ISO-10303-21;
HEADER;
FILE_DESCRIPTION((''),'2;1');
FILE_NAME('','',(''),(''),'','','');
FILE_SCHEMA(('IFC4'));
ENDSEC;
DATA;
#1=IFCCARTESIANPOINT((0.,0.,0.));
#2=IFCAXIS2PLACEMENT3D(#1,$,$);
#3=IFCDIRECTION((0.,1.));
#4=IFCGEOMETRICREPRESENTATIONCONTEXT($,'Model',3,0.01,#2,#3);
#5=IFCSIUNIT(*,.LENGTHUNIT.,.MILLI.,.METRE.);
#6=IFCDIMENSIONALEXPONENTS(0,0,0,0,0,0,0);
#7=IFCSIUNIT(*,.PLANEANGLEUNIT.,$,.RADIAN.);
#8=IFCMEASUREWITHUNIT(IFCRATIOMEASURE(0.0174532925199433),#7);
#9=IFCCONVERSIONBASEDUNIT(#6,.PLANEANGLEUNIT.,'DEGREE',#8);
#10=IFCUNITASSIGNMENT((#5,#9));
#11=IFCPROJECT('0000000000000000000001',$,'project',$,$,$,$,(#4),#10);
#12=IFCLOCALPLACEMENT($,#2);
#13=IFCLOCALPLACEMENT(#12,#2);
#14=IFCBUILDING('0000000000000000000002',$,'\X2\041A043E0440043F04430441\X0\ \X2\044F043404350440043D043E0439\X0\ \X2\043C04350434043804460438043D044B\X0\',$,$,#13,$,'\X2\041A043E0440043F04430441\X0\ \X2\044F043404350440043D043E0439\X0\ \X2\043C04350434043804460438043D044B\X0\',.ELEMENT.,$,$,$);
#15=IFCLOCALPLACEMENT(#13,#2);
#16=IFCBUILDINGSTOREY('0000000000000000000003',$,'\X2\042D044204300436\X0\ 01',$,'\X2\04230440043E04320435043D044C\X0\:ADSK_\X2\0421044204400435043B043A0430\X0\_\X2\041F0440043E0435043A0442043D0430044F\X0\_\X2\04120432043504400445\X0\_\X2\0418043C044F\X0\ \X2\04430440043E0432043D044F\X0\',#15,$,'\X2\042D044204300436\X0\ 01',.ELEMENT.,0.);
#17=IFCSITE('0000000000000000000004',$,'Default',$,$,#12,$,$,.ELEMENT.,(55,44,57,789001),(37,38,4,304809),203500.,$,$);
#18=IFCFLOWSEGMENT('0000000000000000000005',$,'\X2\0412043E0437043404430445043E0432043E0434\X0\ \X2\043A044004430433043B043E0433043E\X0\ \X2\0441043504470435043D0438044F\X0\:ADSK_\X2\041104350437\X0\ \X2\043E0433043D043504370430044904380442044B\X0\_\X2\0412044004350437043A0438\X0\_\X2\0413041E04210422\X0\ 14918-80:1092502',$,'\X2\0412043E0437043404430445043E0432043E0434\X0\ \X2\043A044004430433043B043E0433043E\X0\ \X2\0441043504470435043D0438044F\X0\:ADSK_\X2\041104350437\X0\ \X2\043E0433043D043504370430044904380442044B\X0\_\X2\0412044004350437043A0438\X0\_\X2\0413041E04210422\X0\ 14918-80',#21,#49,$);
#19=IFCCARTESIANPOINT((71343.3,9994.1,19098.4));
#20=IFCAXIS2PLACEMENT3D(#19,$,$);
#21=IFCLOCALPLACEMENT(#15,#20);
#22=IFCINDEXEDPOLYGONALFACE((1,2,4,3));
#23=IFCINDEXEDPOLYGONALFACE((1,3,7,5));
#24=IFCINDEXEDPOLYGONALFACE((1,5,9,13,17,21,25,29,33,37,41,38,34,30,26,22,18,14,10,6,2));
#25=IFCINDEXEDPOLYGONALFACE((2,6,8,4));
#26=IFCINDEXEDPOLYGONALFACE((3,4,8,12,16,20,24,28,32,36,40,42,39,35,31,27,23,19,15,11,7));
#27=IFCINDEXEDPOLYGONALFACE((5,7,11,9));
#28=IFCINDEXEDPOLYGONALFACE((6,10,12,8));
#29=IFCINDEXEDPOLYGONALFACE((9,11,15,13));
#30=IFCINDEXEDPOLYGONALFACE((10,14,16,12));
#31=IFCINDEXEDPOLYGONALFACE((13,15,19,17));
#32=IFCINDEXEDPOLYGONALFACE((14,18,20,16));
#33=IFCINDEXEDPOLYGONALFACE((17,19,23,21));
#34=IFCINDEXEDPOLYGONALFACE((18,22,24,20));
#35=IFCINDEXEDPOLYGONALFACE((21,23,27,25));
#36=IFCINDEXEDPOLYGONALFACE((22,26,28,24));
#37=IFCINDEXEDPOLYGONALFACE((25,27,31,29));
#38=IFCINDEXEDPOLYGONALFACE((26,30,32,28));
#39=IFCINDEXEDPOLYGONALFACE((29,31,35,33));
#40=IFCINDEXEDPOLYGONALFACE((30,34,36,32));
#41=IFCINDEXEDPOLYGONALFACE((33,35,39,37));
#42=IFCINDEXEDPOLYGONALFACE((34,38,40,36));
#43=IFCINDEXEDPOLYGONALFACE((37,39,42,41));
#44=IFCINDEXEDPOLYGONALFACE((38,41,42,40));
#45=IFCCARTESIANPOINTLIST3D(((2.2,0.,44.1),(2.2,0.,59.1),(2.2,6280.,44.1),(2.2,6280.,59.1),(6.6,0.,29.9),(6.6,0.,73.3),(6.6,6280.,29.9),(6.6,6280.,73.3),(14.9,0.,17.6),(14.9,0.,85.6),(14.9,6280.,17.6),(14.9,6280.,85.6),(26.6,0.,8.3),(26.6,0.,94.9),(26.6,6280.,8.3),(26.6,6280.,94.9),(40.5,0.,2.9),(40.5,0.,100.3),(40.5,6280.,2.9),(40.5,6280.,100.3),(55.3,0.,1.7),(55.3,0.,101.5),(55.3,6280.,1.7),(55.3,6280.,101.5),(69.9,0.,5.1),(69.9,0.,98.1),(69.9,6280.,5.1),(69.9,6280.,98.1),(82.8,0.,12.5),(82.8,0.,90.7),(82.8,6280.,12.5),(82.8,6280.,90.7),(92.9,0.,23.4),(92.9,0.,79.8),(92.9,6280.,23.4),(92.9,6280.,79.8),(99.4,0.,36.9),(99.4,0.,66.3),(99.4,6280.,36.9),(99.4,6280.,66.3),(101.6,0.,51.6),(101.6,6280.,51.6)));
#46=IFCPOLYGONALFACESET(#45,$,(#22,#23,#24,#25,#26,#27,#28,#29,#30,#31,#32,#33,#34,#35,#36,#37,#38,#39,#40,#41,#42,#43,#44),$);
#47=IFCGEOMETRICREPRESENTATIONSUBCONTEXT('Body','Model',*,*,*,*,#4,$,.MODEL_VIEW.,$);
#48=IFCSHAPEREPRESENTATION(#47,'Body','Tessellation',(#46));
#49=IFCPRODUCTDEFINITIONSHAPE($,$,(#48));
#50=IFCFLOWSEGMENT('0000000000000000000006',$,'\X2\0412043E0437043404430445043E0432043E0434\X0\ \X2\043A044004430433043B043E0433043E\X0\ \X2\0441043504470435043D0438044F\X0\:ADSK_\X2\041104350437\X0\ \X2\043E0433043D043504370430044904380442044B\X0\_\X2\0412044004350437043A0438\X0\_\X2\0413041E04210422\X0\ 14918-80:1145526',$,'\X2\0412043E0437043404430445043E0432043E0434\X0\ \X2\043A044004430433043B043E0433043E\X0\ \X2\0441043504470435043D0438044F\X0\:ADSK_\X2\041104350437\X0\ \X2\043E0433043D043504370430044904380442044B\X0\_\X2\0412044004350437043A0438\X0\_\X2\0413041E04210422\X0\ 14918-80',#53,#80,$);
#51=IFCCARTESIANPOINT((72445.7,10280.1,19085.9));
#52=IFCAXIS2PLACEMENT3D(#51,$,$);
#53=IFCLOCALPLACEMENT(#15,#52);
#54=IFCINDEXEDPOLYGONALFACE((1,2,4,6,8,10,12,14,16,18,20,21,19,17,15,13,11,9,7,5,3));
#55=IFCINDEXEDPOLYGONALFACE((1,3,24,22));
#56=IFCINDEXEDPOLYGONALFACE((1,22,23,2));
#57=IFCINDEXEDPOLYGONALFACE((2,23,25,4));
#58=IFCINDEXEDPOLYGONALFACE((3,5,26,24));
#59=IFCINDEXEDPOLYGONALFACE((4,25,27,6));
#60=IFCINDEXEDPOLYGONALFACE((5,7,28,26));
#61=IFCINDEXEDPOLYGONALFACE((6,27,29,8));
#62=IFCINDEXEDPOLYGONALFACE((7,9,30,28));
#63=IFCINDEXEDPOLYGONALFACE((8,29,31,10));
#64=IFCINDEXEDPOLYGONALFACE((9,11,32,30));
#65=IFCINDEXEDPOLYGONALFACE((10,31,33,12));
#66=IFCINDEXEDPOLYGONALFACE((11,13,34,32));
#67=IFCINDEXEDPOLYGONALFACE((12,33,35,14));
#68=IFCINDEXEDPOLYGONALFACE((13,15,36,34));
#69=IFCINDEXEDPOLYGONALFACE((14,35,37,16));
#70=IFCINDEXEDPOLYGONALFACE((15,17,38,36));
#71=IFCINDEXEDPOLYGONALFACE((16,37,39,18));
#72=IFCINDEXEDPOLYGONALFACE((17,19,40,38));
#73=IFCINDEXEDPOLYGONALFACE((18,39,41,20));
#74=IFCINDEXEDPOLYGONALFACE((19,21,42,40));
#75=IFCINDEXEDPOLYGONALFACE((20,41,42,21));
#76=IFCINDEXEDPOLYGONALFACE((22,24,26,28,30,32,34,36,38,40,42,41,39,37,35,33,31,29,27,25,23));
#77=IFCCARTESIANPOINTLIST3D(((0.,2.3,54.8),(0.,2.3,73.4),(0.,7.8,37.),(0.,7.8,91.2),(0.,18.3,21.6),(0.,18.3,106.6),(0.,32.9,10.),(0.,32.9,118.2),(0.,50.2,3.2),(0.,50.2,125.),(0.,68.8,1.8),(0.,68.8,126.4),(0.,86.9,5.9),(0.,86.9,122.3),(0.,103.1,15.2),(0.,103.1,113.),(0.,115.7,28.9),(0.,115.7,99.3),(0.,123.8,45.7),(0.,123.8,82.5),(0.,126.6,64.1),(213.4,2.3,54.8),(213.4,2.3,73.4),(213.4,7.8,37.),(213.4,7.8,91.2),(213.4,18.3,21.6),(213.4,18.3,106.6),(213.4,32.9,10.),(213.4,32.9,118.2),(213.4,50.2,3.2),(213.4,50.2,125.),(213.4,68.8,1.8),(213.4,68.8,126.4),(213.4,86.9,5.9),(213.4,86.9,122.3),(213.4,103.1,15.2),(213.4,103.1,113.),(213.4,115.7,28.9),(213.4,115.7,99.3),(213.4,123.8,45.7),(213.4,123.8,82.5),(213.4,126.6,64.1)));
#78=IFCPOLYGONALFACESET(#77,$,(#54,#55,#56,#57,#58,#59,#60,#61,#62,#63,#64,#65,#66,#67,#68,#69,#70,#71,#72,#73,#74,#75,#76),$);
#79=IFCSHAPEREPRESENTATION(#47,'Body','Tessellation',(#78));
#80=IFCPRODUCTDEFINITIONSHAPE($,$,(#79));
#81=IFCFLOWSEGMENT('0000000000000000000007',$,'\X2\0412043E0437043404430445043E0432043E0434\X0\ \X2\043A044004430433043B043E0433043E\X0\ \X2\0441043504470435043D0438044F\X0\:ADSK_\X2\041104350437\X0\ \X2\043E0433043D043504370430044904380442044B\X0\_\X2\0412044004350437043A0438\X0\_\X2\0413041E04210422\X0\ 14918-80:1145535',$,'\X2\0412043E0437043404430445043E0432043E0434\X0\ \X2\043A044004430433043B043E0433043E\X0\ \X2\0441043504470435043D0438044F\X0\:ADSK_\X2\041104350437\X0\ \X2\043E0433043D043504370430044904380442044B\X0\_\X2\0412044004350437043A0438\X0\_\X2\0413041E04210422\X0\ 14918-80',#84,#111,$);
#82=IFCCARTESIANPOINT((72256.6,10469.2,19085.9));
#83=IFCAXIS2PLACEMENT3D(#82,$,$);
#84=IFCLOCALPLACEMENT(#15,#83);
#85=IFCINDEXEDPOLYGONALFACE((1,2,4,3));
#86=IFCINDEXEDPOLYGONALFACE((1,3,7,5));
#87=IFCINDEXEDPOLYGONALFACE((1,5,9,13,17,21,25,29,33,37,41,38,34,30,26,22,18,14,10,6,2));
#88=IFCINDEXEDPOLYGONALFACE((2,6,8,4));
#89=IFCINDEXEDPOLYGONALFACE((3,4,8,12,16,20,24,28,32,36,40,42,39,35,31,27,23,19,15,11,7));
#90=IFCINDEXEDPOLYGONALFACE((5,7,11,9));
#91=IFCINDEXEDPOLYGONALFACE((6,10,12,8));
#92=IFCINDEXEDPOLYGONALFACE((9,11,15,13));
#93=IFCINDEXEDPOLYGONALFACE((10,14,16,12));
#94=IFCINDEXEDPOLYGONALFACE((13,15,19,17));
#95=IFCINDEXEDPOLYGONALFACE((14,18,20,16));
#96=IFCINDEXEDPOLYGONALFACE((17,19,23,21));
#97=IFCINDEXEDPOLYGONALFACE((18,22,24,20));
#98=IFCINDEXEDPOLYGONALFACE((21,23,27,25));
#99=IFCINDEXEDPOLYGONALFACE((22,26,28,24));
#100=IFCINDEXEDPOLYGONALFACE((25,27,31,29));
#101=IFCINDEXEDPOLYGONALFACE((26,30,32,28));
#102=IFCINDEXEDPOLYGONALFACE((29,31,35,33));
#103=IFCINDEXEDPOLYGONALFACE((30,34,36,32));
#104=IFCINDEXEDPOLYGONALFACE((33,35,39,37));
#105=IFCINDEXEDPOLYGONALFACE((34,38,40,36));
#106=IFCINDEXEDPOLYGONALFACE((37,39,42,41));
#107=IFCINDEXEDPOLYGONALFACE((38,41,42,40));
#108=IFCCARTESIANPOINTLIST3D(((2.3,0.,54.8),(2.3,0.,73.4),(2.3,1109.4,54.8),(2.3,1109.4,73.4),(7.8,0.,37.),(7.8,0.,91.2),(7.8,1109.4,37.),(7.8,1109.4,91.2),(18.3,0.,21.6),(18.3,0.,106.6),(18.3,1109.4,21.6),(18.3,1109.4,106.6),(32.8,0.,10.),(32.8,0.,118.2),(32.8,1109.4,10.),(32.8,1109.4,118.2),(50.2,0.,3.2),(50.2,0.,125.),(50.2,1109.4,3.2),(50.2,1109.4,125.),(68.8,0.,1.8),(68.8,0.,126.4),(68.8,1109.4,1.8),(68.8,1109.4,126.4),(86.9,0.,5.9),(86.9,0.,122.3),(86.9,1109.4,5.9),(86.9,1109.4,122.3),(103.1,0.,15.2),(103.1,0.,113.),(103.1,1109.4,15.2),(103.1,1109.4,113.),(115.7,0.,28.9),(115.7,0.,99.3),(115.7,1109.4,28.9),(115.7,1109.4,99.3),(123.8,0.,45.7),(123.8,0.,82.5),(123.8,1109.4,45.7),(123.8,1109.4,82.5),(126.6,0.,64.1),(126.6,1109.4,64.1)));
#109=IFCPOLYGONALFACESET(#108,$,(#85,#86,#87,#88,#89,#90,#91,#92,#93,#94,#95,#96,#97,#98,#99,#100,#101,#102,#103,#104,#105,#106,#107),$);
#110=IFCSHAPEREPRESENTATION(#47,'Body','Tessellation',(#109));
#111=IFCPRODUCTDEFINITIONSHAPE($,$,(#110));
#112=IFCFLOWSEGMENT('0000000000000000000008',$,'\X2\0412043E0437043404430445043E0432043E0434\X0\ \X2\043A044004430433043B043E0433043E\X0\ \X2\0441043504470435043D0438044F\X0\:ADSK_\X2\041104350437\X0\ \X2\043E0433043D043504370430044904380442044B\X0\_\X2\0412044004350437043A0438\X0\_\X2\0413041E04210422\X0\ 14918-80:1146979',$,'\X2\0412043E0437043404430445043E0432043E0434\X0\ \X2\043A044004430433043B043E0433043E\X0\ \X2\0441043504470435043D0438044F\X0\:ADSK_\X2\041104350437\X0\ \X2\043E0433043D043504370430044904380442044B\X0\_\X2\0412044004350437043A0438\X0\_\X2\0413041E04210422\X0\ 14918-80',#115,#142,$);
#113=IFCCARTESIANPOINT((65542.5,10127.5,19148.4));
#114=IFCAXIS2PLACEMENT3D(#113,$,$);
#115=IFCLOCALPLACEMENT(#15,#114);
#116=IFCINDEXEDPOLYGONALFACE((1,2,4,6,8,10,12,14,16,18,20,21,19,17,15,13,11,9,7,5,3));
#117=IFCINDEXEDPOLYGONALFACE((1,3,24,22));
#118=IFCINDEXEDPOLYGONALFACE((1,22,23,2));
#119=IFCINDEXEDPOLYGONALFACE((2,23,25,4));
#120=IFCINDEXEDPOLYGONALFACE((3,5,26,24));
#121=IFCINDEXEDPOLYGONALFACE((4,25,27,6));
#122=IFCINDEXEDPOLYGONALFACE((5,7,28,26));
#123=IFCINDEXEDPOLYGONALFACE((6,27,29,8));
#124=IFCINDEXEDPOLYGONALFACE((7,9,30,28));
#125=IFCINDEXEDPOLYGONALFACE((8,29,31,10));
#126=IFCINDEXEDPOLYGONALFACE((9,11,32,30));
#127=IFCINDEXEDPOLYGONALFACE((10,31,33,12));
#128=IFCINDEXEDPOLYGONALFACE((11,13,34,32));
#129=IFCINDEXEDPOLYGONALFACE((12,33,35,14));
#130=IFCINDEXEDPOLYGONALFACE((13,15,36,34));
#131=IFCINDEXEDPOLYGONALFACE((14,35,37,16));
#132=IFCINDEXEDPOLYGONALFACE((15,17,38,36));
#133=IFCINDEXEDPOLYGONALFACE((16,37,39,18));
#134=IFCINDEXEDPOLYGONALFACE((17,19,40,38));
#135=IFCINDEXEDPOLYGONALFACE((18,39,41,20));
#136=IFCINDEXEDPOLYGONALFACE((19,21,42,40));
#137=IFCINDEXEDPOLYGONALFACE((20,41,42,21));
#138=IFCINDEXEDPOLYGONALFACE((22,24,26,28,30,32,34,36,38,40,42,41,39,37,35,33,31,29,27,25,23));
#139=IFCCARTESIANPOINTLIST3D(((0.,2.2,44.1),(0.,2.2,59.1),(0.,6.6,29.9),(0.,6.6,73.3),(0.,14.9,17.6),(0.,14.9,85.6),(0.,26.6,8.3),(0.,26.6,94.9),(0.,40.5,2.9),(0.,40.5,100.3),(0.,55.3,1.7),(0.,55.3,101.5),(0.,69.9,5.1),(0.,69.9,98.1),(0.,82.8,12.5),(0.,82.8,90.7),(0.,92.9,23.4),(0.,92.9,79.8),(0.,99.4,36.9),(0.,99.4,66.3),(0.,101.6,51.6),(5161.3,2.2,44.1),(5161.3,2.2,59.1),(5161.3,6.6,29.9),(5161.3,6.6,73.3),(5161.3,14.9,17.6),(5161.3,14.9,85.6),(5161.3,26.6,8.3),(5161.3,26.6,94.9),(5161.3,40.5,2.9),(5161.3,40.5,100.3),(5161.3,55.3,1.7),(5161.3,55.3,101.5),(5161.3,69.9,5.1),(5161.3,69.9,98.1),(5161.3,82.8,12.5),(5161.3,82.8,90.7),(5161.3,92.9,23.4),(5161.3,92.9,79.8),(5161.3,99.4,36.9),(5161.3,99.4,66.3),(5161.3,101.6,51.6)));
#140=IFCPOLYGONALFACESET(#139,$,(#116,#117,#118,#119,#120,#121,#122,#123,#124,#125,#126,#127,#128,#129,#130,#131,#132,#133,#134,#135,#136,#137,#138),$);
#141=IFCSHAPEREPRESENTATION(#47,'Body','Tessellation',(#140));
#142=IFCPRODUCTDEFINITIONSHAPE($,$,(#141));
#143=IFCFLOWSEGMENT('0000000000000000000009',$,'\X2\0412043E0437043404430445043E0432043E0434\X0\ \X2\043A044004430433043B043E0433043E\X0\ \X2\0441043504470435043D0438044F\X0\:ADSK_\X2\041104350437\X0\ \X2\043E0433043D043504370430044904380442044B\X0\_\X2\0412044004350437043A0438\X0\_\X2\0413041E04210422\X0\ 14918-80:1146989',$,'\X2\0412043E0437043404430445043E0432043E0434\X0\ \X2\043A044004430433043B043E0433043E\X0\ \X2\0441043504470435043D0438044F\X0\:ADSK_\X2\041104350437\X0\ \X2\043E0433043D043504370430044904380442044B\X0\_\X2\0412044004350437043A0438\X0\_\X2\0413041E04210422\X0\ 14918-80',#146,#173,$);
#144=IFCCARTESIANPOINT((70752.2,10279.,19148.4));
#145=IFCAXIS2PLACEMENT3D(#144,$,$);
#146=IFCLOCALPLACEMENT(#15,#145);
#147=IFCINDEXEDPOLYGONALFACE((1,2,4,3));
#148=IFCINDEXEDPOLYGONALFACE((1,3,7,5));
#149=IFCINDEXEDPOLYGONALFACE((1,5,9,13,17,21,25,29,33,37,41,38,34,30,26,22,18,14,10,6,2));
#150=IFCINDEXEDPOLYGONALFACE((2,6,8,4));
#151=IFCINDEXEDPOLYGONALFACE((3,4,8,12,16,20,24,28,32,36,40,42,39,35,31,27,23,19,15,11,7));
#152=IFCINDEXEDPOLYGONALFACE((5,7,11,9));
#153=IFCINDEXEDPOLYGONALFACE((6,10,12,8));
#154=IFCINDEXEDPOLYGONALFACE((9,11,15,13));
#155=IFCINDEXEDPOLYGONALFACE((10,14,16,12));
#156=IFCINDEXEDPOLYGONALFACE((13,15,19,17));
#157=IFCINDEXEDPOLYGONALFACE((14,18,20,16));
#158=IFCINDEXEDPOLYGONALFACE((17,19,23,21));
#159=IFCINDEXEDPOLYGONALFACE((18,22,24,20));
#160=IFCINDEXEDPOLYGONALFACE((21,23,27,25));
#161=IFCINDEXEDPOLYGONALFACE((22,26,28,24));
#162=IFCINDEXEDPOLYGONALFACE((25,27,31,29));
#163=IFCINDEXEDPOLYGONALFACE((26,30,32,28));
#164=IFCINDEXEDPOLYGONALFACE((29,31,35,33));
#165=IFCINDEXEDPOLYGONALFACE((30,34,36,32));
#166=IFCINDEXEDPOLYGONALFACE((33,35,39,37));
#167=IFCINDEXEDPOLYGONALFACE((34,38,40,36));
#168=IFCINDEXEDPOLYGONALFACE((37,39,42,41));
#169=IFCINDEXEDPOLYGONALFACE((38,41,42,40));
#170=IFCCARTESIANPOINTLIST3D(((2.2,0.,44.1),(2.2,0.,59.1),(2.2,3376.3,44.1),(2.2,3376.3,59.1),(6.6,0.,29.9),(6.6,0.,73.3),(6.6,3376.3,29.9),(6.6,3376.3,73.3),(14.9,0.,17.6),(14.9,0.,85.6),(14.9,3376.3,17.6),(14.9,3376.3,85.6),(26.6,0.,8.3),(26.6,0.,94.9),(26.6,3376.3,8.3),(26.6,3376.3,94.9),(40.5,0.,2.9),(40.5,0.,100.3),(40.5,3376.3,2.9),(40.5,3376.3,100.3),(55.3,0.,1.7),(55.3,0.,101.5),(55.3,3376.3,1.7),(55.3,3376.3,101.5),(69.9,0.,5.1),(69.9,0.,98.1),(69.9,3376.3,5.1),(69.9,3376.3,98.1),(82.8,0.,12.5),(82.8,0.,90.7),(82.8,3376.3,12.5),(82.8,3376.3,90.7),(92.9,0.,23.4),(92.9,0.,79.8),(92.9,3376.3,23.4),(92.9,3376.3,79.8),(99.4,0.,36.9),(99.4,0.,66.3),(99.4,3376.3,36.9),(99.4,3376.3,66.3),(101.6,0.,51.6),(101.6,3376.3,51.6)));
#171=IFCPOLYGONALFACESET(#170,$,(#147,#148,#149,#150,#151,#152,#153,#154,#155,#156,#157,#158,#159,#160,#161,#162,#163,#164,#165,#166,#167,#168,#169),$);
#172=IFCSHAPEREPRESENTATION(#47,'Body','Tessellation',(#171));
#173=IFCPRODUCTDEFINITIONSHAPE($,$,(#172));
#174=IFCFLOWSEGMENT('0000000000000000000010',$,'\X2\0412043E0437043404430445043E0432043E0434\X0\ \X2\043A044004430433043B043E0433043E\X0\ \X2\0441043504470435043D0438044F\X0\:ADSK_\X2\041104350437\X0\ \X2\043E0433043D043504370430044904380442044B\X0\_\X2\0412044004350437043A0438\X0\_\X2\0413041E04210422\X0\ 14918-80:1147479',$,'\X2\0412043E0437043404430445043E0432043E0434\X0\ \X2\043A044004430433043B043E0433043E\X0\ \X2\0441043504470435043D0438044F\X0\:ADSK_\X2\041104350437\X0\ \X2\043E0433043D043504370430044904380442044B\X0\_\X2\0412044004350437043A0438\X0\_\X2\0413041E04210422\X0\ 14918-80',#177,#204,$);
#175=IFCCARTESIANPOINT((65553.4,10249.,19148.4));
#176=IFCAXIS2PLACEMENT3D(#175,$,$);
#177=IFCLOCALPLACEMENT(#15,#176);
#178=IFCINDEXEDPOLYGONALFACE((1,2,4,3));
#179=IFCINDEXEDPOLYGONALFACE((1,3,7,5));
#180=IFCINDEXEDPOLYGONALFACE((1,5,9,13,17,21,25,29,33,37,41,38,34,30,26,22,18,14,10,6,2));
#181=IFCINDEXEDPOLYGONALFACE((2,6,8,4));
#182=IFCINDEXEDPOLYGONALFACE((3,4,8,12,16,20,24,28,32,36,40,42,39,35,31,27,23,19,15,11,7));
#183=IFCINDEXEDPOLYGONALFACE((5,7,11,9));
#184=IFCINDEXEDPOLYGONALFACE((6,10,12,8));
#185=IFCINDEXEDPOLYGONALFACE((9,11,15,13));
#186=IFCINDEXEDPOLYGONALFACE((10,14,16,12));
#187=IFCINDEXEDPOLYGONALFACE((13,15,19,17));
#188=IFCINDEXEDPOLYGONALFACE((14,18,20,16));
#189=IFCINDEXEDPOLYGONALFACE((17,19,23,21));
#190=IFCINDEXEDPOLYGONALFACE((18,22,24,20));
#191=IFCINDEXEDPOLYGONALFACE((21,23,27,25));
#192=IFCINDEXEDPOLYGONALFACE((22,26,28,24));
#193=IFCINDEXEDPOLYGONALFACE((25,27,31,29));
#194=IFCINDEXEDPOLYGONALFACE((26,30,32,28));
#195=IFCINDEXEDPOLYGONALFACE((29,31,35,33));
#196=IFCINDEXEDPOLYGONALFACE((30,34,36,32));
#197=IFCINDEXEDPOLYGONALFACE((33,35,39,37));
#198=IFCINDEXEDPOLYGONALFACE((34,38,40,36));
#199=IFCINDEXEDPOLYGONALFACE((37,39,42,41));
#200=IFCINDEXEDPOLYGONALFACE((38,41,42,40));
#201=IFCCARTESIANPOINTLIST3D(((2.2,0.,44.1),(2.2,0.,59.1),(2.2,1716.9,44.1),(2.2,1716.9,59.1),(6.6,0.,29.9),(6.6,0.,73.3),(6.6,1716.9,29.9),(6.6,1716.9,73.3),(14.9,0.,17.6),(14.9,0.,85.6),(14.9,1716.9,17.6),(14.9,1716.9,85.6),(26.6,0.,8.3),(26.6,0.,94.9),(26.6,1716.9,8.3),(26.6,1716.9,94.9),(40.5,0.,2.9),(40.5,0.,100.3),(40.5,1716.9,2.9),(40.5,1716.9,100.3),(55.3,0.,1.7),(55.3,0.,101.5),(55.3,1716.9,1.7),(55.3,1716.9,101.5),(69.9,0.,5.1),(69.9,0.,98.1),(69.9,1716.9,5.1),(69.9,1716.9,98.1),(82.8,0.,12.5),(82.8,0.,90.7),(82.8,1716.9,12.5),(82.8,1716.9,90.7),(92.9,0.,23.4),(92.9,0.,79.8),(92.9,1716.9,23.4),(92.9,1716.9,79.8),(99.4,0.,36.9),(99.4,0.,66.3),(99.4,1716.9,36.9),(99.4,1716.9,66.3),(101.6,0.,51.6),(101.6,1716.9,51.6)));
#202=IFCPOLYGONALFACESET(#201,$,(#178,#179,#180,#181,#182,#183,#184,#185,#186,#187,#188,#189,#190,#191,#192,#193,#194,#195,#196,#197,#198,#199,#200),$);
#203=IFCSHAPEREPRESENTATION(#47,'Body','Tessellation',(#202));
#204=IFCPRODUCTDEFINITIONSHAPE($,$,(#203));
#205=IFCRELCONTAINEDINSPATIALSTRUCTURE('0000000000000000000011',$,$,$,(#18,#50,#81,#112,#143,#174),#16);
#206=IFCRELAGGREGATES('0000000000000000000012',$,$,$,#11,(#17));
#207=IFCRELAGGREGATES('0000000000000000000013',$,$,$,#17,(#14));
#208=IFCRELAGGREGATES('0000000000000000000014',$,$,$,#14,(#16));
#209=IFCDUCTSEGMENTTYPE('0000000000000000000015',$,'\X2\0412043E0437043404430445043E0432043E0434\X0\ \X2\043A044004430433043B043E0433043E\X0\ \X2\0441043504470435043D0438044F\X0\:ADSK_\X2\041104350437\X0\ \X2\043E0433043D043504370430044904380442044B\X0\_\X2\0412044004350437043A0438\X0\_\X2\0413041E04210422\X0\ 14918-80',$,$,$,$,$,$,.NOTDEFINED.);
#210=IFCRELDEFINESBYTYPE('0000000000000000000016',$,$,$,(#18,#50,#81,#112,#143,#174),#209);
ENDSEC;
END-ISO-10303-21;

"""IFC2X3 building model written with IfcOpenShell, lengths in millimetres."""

from ifc_helpers import new_model, entity, si_unit, converted_unit, direction, frame, origin, origin_2d_with_axis, place, context, subcontext, project, spatial, circle, extrude, type_object, element, save


model = new_model("IFC2X3")

# Units and contexts
model_context = context("Model", 3, precision=0.01, world=origin(), true_north=direction((0.0, 1.0)))
body_context = subcontext(model_context, "Body", "Model", "MODEL_VIEW")
ifc_project = project(units=[si_unit("LENGTHUNIT", "METRE", prefix="MILLI"), converted_unit("PLANEANGLEUNIT", "DEGREE", entity("IfcRatioMeasure", 0.0174532925199433), si_unit("PLANEANGLEUNIT", "RADIAN"), dimensions=[0, 0, 0, 0, 0, 0, 0])], contexts=[model_context])

# Site, building, storey
site_placement = place(None, origin())
site = spatial("IfcSite", under=ifc_project, at=site_placement, Name="Default", CompositionType="ELEMENT", RefLatitude=(55, 44, 57, 789001), RefLongitude=(37, 38, 4, 304809), RefElevation=203500.0)
building_placement = place(site_placement, origin())
building = spatial("IfcBuilding", under=site, at=building_placement, Name="Корпус ядерной медицины", LongName="Корпус ядерной медицины", CompositionType="ELEMENT")
storey_placement = place(building_placement, origin())
storey = spatial("IfcBuildingStorey", under=building, at=storey_placement, Name="Этаж 01", ObjectType="Уровень:ADSK_Стрелка_Проектная_Вверх_Имя уровня", LongName="Этаж 01", CompositionType="ELEMENT", Elevation=0.0)

# Flow segments
duct_segment_type_1 = type_object("IfcDuctSegmentType", Name="Воздуховод круглого сечения:ADSK_Без огнезащиты_Врезки_ГОСТ 14918-80", PredefinedType="NOTDEFINED")
flow_segment_1_placement = place(storey_placement, frame((71343.3, 9994.1, 19098.4)))
element("IfcFlowSegment", 1, at=flow_segment_1_placement, inside=storey, type_object=duct_segment_type_1, Name="Воздуховод круглого сечения:ADSK_Без огнезащиты_Врезки_ГОСТ 14918-80:1092502", ObjectType="Воздуховод круглого сечения:ADSK_Без огнезащиты_Врезки_ГОСТ 14918-80", context=body_context, shape_type="SweptSolid", body=[
    extrude(circle(Radius=50.0, at=origin_2d_with_axis()), frame((51.6, 0.0, 51.6), z_axis=(0.0, 1.0, 0.0), x_axis=(1.0, 0.0, 0.0)), (0.0, 0.0, 1.0), 6280.0),
])
flow_segment_2_placement = place(storey_placement, frame((72445.7, 10280.1, 19085.9)))
element("IfcFlowSegment", 2, at=flow_segment_2_placement, inside=storey, type_object=duct_segment_type_1, Name="Воздуховод круглого сечения:ADSK_Без огнезащиты_Врезки_ГОСТ 14918-80:1145526", ObjectType="Воздуховод круглого сечения:ADSK_Без огнезащиты_Врезки_ГОСТ 14918-80", context=body_context, shape_type="SweptSolid", body=[
    extrude(circle(Radius=62.5, at=origin_2d_with_axis()), frame((0.0, 64.1, 64.1), z_axis=(1.0, 0.0, 0.0), x_axis=(0.0, 1.0, 0.0)), (0.0, 0.0, 1.0), 213.4),
])
flow_segment_3_placement = place(storey_placement, frame((72256.6, 10469.2, 19085.9)))
element("IfcFlowSegment", 3, at=flow_segment_3_placement, inside=storey, type_object=duct_segment_type_1, Name="Воздуховод круглого сечения:ADSK_Без огнезащиты_Врезки_ГОСТ 14918-80:1145535", ObjectType="Воздуховод круглого сечения:ADSK_Без огнезащиты_Врезки_ГОСТ 14918-80", context=body_context, shape_type="SweptSolid", body=[
    extrude(circle(Radius=62.5, at=origin_2d_with_axis()), frame((64.1, 0.0, 64.1), z_axis=(0.0, 1.0, 0.0), x_axis=(1.0, 0.0, 0.0)), (0.0, 0.0, 1.0), 1109.4),
])
flow_segment_4_placement = place(storey_placement, frame((65542.5, 10127.5, 19148.4)))
element("IfcFlowSegment", 4, at=flow_segment_4_placement, inside=storey, type_object=duct_segment_type_1, Name="Воздуховод круглого сечения:ADSK_Без огнезащиты_Врезки_ГОСТ 14918-80:1146979", ObjectType="Воздуховод круглого сечения:ADSK_Без огнезащиты_Врезки_ГОСТ 14918-80", context=body_context, shape_type="SweptSolid", body=[
    extrude(circle(Radius=50.0, at=origin_2d_with_axis()), frame((0.0, 51.6, 51.6), z_axis=(1.0, 0.0, 0.0), x_axis=(0.0, 1.0, 0.0)), (0.0, 0.0, 1.0), 5161.3),
])
flow_segment_5_placement = place(storey_placement, frame((70752.2, 10279.0, 19148.4)))
element("IfcFlowSegment", 5, at=flow_segment_5_placement, inside=storey, type_object=duct_segment_type_1, Name="Воздуховод круглого сечения:ADSK_Без огнезащиты_Врезки_ГОСТ 14918-80:1146989", ObjectType="Воздуховод круглого сечения:ADSK_Без огнезащиты_Врезки_ГОСТ 14918-80", context=body_context, shape_type="SweptSolid", body=[
    extrude(circle(Radius=50.0, at=origin_2d_with_axis()), frame((51.6, 0.0, 51.6), z_axis=(0.0, 1.0, 0.0), x_axis=(1.0, 0.0, 0.0)), (0.0, 0.0, 1.0), 3376.3),
])
flow_segment_6_placement = place(storey_placement, frame((65553.4, 10249.0, 19148.4)))
element("IfcFlowSegment", 6, at=flow_segment_6_placement, inside=storey, type_object=duct_segment_type_1, Name="Воздуховод круглого сечения:ADSK_Без огнезащиты_Врезки_ГОСТ 14918-80:1147479", ObjectType="Воздуховод круглого сечения:ADSK_Без огнезащиты_Врезки_ГОСТ 14918-80", context=body_context, shape_type="SweptSolid", body=[
    extrude(circle(Radius=50.0, at=origin_2d_with_axis()), frame((51.6, 0.0, 51.6), z_axis=(0.0, 1.0, 0.0), x_axis=(1.0, 0.0, 0.0)), (0.0, 0.0, 1.0), 1716.9),
])

save(model, "model.ifc")
